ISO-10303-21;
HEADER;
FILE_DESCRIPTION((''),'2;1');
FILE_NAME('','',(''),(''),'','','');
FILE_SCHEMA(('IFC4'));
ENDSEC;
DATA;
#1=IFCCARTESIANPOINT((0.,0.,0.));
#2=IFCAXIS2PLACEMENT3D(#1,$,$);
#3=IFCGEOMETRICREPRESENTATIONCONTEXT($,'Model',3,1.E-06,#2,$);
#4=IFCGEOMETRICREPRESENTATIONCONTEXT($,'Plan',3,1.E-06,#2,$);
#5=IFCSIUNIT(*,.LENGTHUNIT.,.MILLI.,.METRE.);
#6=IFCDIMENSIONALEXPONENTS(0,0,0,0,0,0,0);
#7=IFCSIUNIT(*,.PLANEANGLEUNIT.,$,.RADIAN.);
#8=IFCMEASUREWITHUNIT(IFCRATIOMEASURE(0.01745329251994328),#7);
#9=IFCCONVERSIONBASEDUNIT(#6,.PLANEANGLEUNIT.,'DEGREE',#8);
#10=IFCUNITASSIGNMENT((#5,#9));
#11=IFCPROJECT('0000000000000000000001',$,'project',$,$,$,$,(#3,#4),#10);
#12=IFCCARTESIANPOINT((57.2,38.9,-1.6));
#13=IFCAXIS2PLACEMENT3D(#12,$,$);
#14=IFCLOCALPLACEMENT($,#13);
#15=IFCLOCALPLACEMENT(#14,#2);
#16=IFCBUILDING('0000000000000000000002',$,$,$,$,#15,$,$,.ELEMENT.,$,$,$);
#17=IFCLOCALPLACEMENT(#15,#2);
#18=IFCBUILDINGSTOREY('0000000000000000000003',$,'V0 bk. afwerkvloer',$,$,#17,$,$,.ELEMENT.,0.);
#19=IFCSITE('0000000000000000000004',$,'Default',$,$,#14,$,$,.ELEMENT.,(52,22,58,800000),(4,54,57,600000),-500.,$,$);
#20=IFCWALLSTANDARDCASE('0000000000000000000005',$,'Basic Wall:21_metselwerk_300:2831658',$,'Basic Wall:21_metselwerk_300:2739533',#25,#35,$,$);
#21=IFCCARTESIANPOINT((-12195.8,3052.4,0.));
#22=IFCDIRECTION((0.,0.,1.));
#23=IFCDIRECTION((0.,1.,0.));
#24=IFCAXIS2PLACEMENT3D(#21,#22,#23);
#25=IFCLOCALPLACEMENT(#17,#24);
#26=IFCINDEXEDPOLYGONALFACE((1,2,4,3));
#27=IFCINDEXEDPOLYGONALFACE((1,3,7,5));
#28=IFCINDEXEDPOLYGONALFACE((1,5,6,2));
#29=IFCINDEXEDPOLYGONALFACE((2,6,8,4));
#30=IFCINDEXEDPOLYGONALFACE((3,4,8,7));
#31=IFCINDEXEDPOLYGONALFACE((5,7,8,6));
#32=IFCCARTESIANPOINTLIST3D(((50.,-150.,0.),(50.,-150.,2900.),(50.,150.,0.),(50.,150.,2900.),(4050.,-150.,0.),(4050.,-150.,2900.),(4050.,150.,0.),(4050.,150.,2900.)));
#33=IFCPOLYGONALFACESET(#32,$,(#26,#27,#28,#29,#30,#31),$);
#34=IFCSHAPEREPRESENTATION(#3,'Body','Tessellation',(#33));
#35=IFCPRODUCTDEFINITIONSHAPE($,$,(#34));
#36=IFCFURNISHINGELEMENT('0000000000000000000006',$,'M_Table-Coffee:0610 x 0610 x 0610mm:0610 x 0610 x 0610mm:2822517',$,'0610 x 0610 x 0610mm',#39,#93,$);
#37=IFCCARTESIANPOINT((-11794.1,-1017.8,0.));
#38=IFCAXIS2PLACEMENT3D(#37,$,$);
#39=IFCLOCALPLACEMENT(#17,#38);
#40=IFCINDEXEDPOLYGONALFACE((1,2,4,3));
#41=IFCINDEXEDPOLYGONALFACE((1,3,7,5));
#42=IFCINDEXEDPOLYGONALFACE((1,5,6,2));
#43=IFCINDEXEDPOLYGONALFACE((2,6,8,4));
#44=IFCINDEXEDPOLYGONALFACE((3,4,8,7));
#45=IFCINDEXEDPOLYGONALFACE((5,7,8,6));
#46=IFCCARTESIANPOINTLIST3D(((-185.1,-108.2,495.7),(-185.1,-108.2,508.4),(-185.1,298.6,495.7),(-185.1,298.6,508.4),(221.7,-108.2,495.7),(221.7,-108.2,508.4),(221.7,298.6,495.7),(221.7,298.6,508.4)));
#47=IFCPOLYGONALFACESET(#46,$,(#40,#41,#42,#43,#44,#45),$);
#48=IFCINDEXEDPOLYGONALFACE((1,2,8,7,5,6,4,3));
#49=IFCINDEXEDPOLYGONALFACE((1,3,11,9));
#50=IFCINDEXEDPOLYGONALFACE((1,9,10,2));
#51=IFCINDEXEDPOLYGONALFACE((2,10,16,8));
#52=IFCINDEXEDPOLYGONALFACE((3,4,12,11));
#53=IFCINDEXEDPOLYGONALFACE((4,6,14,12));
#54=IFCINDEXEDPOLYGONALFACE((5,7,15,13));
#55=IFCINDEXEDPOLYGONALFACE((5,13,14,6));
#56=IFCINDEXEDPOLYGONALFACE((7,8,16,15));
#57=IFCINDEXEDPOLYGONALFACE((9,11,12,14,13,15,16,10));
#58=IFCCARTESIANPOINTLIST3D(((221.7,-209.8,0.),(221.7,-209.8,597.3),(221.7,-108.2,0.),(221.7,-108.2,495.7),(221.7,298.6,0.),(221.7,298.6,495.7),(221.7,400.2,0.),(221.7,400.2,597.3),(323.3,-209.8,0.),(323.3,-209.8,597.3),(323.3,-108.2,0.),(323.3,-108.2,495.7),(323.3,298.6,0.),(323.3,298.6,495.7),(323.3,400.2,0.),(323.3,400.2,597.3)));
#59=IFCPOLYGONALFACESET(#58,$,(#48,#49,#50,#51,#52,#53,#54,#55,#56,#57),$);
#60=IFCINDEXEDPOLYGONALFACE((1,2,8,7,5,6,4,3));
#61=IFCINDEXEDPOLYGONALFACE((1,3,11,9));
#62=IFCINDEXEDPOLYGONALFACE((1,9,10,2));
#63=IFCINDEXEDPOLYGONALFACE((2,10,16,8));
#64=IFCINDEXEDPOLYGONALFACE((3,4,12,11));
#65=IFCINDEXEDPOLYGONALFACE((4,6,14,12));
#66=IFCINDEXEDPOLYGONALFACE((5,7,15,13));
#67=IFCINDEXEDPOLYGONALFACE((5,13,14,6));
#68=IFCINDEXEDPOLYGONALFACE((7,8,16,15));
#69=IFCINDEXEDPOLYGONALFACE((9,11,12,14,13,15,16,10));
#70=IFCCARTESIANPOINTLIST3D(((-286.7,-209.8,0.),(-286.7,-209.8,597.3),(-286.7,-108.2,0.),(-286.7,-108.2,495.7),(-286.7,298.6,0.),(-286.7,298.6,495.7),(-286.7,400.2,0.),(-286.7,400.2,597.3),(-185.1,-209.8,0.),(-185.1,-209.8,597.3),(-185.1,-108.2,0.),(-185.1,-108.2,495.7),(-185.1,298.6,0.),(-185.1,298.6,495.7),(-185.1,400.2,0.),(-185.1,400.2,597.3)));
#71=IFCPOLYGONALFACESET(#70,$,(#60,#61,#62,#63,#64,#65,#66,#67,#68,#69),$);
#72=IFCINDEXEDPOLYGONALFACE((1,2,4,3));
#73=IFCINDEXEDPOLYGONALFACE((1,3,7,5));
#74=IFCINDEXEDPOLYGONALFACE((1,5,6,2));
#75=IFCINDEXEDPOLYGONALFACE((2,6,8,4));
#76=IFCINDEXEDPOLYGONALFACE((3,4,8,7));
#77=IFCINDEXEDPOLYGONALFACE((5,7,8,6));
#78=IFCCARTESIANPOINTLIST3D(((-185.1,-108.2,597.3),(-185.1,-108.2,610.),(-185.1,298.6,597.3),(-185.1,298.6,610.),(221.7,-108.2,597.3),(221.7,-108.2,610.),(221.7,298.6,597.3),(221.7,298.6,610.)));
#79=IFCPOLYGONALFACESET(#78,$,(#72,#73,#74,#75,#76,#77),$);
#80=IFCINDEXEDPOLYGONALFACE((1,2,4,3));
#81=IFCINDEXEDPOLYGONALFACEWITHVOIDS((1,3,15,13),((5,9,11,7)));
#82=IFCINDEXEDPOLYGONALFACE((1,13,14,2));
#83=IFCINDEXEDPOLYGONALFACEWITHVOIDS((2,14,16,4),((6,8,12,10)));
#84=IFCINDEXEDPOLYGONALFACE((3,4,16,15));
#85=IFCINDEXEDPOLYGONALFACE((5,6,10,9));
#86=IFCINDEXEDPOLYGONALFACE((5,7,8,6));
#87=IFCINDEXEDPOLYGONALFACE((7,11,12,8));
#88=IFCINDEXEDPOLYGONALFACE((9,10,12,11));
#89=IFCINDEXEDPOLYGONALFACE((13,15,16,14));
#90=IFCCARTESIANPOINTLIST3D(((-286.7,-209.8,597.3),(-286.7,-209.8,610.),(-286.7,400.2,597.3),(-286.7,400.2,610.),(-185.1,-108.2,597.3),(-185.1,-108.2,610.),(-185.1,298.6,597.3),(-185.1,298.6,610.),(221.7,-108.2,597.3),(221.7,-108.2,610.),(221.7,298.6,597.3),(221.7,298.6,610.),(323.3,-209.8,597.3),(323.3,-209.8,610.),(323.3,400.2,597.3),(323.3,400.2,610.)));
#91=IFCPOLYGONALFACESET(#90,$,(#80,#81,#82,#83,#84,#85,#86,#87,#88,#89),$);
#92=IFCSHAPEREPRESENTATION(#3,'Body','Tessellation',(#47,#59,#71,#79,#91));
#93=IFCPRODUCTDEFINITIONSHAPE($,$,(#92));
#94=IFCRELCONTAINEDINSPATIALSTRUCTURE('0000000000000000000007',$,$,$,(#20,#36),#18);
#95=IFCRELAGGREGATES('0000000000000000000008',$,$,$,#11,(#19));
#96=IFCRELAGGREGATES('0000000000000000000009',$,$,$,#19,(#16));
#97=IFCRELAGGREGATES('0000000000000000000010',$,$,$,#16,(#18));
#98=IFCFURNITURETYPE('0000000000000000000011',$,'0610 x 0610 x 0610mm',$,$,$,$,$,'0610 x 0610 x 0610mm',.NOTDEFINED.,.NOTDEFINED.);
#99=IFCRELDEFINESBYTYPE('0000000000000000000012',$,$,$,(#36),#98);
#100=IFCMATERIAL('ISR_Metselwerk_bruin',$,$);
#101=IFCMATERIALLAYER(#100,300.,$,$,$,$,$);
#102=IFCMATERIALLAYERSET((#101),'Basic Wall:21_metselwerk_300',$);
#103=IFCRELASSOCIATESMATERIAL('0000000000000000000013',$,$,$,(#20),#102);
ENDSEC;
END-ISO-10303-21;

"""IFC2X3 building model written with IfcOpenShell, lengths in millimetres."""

from ifc_helpers import new_model, entity, si_unit, converted_unit, frame, frame_2d, origin, origin_2d_with_axis, place, context, project, spatial, polyline, rectangle, outline, extrude, source, transform, mapped, material, layer, layer_set, layer_usage, type_object, type_shapes, element, save


model = new_model("IFC2X3")

# Units and contexts
model_context = context("Model", 3, precision=1e-06, world=origin())
plan_context = context("Plan", 3, precision=1e-06, world=origin())
ifc_project = project(units=[si_unit("LENGTHUNIT", "METRE", prefix="MILLI"), converted_unit("PLANEANGLEUNIT", "DEGREE", entity("IfcRatioMeasure", 0.01745329251994328), si_unit("PLANEANGLEUNIT", "RADIAN"), dimensions=[0, 0, 0, 0, 0, 0, 0])], contexts=[model_context, plan_context])

# Site, building, storey
site_placement = place(None, frame((57.2, 38.9, -1.6)))
site = spatial("IfcSite", under=ifc_project, at=site_placement, Name="Default", CompositionType="ELEMENT", RefLatitude=(52, 22, 58, 800000), RefLongitude=(4, 54, 57, 600000), RefElevation=-500.0)
building_placement = place(site_placement, origin())
building = spatial("IfcBuilding", under=site, at=building_placement, CompositionType="ELEMENT")
storey_placement = place(building_placement, origin())
storey = spatial("IfcBuildingStorey", under=building, at=storey_placement, Name="V0 bk. afwerkvloer", CompositionType="ELEMENT", Elevation=0.0)

# Wall
ifc_material_1 = material(Name="ISR_Metselwerk_bruin")
ifc_layer_1 = layer(ifc_material_1, 300.0)
ifc_layer_set_1 = layer_set([ifc_layer_1], Name="Basic Wall:21_metselwerk_300")
ifc_layer_usage_1 = layer_usage(ifc_layer_set_1, "AXIS2", "NEGATIVE", 150.0)
wall_1_placement = place(storey_placement, frame((-12195.8, 3052.4, 0.0), z_axis=(0.0, 0.0, 1.0), x_axis=(0.0, 1.0, 0.0)))
element("IfcWallStandardCase", 1, at=wall_1_placement, inside=storey, material=ifc_layer_usage_1, Name="Basic Wall:21_metselwerk_300:2831658", ObjectType="Basic Wall:21_metselwerk_300:2739533", context=model_context, shape_type="SweptSolid", body=[
    extrude(rectangle(XDim=4000.0, YDim=300.0, at=frame_2d((2050.0, 0.0), x_axis=(-1.0, 0.0))), origin(), (0.0, 0.0, 1.0), 2900.0),
])

# Furnishing element
furniture_type = type_object("IfcFurnitureType", Name="0610 x 0610 x 0610mm", ElementType="0610 x 0610 x 0610mm", AssemblyPlace="NOTDEFINED")
shared_shape_1 = source(origin(), model_context, "Body", "SweptSolid", [
    extrude(rectangle(XDim=406.8, YDim=406.8, at=origin_2d_with_axis()), frame((18.3, 95.2, 495.7), z_axis=(0.0, 0.0, 1.0), x_axis=(-1.0, 0.0, 0.0)), (0.0, 0.0, 1.0), 12.7),
    extrude(outline(polyline([(-273.2, -305.0), (324.0, -305.0), (324.0, 305.0), (-273.2, 305.0), (-273.2, 203.4), (222.5, 203.4), (222.5, -203.4), (-273.2, -203.4), (-273.2, -305.0)])), frame((221.7, 95.2, 273.2), z_axis=(1.0, 0.0, 0.0), x_axis=(0.0, 0.0, 1.0)), (0.0, 0.0, 1.0), 101.6),
    extrude(outline(polyline([(-305.0, -324.1), (305.0, -324.1), (305.0, 273.3), (203.4, 273.3), (203.4, -222.4), (-203.4, -222.4), (-203.4, 273.3), (-305.0, 273.3), (-305.0, -324.1)])), frame((-286.7, 95.2, 273.3), z_axis=(1.0, 0.0, 0.0), x_axis=(0.0, -1.0, 0.0)), (0.0, 0.0, 1.0), 101.6),
    extrude(rectangle(XDim=406.8, YDim=406.8, at=origin_2d_with_axis()), frame((18.3, 95.2, 597.3), z_axis=(0.0, 0.0, 1.0), x_axis=(-1.0, 0.0, 0.0)), (0.0, 0.0, 1.0), 12.7),
    extrude(outline(polyline([(-305.0, -305.0), (305.0, -305.0), (305.0, 305.0), (-305.0, 305.0), (-305.0, -305.0)]), holes=[polyline([(-203.4, -203.4), (-203.4, 203.4), (203.4, 203.4), (203.4, -203.4), (-203.4, -203.4)])]), frame((18.3, 95.2, 597.3), z_axis=(0.0, 0.0, 1.0), x_axis=(-1.0, 0.0, 0.0)), (0.0, 0.0, 1.0), 12.7),
])
type_shapes(furniture_type, [shared_shape_1])
furnishing_placement = place(storey_placement, frame((-11794.1, -1017.8, 0.0)))
element("IfcFurnishingElement", 2, at=furnishing_placement, inside=storey, type_object=furniture_type, Name="M_Table-Coffee:0610 x 0610 x 0610mm:0610 x 0610 x 0610mm:2822517", ObjectType="0610 x 0610 x 0610mm", context=model_context, shape_type="MappedRepresentation", body=[
    mapped(shared_shape_1, transform((0.0, 0.0, 0.0), scale=1.0)),
])

save(model, "model.ifc")
